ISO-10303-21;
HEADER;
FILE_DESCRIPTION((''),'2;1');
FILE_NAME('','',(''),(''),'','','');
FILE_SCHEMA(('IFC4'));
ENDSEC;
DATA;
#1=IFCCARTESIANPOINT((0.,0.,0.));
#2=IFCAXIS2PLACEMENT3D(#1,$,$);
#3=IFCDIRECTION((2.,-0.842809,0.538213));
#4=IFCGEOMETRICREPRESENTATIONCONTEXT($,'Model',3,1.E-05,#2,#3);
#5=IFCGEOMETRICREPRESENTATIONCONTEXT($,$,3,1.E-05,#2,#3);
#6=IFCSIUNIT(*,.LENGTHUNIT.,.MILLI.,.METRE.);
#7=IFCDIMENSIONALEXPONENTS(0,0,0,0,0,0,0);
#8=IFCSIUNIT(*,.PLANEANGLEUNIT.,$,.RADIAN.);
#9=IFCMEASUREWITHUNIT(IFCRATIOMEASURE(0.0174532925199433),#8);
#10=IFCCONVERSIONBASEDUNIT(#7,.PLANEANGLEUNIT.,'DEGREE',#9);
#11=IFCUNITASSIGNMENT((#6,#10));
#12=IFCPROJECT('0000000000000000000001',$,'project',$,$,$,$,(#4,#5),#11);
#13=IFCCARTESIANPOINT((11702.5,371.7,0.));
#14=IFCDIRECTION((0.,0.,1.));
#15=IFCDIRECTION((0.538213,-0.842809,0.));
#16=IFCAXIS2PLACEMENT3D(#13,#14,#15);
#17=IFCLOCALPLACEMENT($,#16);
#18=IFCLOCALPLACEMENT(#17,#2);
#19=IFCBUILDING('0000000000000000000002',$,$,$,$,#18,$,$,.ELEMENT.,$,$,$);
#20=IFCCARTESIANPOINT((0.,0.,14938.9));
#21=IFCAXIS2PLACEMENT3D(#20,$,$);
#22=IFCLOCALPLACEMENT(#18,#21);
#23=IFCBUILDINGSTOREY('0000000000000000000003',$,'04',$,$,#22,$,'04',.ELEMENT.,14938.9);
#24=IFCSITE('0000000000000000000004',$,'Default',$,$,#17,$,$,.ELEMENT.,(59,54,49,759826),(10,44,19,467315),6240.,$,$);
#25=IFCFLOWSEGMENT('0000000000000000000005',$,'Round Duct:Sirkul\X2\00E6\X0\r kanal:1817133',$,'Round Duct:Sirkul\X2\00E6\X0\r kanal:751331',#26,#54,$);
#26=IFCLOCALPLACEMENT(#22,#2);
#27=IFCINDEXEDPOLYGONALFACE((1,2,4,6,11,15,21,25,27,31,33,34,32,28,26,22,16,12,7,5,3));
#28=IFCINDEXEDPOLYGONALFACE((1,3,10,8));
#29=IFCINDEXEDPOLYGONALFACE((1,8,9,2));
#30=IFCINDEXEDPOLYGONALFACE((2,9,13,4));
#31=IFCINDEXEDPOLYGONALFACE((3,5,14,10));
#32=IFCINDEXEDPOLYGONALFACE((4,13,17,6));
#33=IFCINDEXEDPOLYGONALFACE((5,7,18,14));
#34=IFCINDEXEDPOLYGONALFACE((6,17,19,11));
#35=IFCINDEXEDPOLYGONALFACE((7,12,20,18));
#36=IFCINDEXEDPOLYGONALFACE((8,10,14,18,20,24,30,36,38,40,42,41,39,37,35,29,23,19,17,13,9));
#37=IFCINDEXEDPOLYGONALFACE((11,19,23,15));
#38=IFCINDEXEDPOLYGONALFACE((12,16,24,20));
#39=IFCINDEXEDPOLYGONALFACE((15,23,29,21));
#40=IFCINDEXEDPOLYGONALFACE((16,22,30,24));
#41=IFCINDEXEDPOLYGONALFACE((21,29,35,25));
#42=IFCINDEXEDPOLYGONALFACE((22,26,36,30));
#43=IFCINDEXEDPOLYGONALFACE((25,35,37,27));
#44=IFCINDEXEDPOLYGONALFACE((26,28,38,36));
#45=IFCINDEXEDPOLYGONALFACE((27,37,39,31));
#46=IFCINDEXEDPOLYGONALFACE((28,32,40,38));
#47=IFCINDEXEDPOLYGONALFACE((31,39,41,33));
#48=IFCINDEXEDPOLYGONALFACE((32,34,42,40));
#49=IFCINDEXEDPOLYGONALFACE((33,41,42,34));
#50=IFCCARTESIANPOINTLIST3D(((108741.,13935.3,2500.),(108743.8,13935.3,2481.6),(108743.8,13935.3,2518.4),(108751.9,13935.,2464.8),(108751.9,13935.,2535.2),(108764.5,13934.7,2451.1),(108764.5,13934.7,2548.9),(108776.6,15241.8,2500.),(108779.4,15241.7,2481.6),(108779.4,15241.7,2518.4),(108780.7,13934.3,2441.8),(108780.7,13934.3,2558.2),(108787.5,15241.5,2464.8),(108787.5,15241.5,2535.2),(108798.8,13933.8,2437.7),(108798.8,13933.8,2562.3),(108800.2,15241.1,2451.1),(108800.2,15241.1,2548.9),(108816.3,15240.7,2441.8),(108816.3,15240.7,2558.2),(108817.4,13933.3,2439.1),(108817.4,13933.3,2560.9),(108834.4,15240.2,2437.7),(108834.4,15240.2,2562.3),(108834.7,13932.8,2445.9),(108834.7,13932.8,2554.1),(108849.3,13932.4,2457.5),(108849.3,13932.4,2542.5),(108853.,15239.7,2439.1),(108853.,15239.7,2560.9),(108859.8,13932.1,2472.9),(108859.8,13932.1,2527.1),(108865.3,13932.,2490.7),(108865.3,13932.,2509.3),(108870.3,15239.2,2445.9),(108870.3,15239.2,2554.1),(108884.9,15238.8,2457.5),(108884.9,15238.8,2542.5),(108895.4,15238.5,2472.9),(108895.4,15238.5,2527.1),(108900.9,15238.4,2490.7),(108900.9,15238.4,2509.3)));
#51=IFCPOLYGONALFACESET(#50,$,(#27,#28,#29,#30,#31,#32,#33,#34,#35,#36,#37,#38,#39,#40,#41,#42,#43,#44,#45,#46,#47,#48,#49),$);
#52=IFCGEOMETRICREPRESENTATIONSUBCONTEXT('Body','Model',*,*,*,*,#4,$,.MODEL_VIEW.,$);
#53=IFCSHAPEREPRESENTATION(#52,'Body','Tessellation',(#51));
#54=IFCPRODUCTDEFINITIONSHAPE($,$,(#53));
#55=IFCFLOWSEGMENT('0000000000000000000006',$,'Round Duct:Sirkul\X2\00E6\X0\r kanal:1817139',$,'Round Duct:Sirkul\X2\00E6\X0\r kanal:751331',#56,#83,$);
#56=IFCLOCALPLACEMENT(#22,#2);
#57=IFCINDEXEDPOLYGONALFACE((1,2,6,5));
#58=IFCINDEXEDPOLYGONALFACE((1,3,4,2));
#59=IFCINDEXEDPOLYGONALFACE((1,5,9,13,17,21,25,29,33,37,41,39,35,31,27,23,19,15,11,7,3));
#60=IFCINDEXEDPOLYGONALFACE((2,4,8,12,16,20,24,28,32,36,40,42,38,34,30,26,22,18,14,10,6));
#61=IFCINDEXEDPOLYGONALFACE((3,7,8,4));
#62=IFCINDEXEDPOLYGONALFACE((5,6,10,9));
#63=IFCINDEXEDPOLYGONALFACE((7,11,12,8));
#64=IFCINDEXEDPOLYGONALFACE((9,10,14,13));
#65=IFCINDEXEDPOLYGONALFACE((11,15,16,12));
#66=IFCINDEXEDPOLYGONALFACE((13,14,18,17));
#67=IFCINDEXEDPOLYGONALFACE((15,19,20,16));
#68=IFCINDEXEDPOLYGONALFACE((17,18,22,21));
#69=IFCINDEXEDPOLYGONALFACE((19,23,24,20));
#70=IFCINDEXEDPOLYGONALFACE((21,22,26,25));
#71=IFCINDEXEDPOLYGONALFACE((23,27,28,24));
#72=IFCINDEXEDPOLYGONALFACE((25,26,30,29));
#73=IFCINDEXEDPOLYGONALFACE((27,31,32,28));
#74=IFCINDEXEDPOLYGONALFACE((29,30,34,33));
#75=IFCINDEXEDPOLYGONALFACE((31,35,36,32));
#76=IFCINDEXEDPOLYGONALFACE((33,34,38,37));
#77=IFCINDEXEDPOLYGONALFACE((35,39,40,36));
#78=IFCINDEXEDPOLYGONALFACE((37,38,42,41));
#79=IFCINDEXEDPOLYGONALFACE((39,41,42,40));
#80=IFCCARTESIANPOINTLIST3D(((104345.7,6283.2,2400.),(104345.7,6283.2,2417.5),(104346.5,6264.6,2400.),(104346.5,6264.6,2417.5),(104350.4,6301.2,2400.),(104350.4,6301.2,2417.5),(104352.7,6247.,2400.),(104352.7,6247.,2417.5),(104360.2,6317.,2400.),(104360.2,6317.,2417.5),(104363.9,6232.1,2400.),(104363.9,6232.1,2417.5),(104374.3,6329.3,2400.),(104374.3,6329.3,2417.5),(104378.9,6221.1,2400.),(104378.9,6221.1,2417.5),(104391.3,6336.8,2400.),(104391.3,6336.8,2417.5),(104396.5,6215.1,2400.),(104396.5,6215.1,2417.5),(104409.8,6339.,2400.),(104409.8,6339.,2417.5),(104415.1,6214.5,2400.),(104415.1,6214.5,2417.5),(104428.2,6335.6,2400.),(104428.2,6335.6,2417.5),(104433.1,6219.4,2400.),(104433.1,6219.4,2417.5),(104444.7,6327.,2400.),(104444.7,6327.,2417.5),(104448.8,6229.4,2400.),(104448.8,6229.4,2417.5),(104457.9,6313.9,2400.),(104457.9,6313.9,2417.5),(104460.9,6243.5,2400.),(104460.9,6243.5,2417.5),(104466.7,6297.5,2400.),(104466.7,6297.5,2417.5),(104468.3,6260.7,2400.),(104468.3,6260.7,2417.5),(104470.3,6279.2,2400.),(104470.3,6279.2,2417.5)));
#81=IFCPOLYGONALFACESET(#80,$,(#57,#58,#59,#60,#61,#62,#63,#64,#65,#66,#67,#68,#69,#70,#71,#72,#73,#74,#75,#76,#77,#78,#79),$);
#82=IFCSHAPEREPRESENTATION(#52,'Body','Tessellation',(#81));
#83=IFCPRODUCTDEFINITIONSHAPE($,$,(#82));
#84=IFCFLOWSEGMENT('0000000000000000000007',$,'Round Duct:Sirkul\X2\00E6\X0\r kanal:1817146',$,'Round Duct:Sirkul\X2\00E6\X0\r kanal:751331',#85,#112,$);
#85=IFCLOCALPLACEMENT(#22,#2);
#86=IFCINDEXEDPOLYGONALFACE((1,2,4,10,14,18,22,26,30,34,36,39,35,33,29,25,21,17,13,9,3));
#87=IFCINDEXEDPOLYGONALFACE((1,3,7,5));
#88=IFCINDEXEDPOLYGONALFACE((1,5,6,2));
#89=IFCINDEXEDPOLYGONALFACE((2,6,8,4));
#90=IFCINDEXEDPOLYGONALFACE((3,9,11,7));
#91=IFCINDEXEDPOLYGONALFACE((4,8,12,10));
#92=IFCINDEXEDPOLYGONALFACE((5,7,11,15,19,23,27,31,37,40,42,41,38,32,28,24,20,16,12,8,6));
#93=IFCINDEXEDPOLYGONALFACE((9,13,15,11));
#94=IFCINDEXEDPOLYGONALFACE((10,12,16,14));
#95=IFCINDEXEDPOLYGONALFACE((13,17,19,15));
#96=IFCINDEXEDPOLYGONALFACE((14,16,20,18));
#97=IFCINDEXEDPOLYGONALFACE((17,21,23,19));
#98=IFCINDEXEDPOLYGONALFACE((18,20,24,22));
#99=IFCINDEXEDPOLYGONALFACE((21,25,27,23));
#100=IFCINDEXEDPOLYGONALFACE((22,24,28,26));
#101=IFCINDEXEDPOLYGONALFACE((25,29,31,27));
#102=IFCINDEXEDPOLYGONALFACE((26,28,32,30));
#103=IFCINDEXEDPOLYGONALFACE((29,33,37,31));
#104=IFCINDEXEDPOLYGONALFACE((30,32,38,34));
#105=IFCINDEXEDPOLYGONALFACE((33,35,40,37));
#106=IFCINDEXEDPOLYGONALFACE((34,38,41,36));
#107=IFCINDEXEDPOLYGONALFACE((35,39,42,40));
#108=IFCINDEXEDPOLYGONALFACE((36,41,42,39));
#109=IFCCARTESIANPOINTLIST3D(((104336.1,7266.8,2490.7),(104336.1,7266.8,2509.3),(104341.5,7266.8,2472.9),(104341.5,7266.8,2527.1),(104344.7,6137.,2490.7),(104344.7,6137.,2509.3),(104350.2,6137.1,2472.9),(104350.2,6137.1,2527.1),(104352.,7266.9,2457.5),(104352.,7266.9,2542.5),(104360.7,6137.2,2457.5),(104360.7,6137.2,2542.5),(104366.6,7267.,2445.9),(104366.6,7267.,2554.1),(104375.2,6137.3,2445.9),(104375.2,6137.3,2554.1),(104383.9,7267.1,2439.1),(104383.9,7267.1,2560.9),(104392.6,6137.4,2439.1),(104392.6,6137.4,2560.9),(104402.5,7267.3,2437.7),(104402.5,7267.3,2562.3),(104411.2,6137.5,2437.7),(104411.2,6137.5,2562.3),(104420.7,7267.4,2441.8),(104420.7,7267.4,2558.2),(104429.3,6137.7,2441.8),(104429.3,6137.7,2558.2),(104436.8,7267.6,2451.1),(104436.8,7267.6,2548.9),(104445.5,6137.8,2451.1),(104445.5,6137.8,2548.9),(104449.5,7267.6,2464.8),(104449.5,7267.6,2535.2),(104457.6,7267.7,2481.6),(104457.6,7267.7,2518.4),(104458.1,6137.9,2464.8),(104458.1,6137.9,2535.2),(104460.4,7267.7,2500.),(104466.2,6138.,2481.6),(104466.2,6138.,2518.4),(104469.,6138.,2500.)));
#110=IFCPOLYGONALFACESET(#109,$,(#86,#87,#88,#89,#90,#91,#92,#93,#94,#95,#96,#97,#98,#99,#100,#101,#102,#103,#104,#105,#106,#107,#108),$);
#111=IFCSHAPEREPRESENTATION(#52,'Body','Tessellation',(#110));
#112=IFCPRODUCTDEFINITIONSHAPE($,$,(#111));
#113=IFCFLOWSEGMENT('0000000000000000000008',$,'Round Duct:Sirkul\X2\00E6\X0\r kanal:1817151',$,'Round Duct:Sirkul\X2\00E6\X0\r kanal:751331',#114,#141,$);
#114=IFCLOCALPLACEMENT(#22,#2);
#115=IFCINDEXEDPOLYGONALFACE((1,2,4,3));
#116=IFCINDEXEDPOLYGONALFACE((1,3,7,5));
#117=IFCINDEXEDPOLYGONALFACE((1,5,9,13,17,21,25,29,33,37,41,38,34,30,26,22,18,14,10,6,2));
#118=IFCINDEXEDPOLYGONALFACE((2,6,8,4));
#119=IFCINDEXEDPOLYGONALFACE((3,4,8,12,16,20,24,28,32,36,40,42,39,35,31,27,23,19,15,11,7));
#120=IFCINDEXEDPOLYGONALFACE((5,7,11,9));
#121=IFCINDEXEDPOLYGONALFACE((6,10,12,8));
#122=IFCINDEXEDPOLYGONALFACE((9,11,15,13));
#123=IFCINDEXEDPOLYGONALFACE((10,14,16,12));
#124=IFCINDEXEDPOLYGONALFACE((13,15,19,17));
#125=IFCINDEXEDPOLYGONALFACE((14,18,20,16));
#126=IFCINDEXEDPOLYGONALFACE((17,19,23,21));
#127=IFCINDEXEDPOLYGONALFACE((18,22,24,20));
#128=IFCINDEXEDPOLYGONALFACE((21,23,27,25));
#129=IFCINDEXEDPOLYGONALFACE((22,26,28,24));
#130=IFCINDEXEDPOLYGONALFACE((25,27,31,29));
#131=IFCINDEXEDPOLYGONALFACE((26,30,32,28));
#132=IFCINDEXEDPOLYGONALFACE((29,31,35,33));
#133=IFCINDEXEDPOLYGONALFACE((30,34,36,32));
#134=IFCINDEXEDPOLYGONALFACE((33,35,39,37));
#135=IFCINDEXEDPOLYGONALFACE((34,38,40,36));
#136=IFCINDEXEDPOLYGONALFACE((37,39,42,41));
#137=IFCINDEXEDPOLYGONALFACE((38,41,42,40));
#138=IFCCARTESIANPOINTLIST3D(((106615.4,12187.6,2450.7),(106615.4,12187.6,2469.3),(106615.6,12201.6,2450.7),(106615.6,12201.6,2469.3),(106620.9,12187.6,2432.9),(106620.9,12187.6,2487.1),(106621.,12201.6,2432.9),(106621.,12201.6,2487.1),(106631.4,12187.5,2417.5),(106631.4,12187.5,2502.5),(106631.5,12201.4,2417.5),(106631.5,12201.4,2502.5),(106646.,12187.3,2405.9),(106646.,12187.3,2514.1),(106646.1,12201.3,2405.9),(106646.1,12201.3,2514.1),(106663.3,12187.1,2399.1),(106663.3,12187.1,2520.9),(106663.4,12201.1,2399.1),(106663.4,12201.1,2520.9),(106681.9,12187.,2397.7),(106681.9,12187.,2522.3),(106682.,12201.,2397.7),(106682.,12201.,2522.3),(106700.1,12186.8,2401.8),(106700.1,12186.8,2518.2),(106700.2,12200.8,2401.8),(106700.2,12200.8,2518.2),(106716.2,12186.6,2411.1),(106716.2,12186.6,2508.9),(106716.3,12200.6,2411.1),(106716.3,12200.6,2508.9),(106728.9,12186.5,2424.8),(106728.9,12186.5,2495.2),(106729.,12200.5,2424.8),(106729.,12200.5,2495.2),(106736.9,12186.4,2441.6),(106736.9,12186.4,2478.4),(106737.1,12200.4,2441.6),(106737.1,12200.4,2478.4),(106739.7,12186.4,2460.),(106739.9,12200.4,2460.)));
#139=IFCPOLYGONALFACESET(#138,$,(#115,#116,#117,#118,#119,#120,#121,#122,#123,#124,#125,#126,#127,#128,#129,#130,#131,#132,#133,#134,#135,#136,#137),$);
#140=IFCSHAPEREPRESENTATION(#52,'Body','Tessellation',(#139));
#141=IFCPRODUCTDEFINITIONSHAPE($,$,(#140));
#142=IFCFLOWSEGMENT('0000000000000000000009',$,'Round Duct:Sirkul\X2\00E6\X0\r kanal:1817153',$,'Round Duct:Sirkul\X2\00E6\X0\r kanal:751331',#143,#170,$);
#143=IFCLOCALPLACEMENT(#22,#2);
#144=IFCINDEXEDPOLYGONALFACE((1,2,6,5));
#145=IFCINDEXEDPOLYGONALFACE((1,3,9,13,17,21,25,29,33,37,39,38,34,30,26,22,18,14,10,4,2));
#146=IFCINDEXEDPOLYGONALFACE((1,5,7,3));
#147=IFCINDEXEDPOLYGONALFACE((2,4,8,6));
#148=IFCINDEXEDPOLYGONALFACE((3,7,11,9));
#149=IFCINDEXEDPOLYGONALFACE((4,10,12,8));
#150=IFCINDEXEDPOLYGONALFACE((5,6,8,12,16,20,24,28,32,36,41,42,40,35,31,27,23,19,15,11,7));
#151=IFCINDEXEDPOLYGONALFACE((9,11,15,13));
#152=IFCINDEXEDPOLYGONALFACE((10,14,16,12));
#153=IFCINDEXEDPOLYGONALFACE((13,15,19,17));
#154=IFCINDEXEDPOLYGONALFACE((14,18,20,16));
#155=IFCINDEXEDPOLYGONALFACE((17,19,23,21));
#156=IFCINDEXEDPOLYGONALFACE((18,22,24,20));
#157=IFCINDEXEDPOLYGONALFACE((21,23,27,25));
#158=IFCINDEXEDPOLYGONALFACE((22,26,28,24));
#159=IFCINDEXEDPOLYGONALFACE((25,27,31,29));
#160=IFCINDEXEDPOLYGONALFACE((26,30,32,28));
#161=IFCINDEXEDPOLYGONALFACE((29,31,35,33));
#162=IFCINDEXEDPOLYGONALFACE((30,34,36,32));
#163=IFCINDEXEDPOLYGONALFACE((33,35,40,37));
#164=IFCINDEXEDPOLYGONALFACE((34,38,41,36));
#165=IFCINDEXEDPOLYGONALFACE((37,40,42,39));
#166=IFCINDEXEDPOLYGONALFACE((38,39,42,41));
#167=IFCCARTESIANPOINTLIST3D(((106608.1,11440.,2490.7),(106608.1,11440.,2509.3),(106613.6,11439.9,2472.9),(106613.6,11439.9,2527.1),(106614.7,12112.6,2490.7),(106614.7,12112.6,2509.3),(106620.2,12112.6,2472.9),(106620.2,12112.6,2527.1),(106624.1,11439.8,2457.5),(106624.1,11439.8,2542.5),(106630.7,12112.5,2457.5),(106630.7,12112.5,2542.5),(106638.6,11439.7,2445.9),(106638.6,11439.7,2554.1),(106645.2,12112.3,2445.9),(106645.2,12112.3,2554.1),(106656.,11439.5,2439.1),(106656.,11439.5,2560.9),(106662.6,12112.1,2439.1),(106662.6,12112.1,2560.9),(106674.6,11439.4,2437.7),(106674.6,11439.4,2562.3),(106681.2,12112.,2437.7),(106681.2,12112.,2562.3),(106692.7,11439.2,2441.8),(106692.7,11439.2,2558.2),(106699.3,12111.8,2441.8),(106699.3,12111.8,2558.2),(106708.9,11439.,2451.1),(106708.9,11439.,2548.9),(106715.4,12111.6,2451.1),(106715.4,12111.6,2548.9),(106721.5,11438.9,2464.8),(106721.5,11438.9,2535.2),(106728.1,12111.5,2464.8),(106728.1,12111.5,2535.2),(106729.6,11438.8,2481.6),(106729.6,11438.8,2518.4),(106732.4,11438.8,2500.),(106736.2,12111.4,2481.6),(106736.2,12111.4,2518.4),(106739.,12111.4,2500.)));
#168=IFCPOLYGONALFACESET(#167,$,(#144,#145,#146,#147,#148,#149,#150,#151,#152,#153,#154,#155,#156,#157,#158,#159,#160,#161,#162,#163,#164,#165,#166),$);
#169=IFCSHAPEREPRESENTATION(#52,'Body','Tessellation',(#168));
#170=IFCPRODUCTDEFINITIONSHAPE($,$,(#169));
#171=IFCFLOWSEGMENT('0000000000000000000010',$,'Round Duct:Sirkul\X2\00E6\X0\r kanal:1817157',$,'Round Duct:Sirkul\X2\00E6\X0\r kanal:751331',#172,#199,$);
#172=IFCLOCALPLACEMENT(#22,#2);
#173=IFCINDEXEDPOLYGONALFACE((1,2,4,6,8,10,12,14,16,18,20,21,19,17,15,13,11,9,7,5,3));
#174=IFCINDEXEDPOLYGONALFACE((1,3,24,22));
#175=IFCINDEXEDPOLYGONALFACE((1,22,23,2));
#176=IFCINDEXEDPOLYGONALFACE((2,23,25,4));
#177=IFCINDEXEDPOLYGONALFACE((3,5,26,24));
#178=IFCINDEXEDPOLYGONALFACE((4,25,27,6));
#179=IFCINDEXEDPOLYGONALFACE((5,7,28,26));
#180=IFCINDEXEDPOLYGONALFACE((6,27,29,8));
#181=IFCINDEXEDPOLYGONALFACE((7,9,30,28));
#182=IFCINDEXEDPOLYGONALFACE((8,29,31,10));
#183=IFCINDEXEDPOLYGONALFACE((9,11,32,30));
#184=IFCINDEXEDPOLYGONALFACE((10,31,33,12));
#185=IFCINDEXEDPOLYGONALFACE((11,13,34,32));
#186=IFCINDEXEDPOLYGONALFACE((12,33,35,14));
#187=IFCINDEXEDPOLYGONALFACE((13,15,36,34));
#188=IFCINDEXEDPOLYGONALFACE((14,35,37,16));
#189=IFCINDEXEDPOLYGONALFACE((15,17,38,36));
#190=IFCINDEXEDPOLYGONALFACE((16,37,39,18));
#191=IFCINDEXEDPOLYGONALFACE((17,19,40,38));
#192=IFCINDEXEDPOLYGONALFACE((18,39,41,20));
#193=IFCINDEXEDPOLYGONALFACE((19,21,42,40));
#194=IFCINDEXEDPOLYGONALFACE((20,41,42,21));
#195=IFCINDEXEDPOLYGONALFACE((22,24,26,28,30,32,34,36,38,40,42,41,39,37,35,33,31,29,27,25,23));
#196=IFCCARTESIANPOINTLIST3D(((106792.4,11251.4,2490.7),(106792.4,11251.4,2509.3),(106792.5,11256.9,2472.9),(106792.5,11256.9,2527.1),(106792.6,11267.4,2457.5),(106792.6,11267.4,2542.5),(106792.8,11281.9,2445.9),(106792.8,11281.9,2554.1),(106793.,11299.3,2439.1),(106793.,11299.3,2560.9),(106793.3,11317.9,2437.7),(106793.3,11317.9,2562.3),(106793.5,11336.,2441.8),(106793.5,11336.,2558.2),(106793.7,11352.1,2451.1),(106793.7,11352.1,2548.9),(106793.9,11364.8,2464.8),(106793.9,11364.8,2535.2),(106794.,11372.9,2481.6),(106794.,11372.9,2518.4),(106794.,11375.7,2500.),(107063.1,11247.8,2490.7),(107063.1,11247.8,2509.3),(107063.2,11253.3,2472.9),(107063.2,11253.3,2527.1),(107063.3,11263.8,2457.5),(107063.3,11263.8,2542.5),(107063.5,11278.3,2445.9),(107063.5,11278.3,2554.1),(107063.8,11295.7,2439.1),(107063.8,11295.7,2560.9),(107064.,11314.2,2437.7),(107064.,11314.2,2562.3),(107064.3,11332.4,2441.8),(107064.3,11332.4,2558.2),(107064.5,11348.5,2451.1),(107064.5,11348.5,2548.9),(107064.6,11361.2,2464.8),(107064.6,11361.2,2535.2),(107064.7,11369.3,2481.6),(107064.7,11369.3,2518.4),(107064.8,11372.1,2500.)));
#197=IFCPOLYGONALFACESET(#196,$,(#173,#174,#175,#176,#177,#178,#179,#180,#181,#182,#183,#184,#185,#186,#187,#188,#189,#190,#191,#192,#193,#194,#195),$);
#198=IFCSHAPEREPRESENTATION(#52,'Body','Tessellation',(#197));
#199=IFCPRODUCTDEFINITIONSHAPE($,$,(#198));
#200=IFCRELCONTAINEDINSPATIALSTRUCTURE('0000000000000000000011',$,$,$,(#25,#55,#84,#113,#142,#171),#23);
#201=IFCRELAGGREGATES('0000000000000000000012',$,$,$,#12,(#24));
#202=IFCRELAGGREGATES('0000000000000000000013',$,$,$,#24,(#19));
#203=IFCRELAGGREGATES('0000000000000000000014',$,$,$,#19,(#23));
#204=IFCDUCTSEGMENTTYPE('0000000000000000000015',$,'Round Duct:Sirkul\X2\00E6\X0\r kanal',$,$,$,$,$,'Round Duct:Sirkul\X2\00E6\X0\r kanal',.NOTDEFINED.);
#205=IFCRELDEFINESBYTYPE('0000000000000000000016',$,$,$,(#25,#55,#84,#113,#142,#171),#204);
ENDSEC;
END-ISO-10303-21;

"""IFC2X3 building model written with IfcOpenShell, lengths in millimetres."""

from ifc_helpers import new_model, entity, si_unit, converted_unit, direction, frame, frame_2d, origin, origin_2d_with_axis, place, context, subcontext, project, spatial, circle, extrude, type_object, element, save


model = new_model("IFC2X3")

# Units and contexts
model_context = context("Model", 3, precision=1e-05, world=origin(), true_north=direction((2.0, -0.842809, 0.538213)))
context_of_model = context(None, 3, precision=1e-05, world=origin(), true_north=direction((2.0, -0.842809, 0.538213)))
body_context = subcontext(model_context, "Body", "Model", "MODEL_VIEW")
ifc_project = project(units=[si_unit("LENGTHUNIT", "METRE", prefix="MILLI"), converted_unit("PLANEANGLEUNIT", "DEGREE", entity("IfcRatioMeasure", 0.0174532925199433), si_unit("PLANEANGLEUNIT", "RADIAN"), dimensions=[0, 0, 0, 0, 0, 0, 0])], contexts=[model_context, context_of_model])

# Site, building, storey
site_placement = place(None, frame((11702.5, 371.7, 0.0), z_axis=(0.0, 0.0, 1.0), x_axis=(0.538213, -0.842809, 0.0)))
site = spatial("IfcSite", under=ifc_project, at=site_placement, Name="Default", CompositionType="ELEMENT", RefLatitude=(59, 54, 49, 759826), RefLongitude=(10, 44, 19, 467315), RefElevation=6240.0)
building_placement = place(site_placement, origin())
building = spatial("IfcBuilding", under=site, at=building_placement, CompositionType="ELEMENT")
storey_placement = place(building_placement, frame((0.0, 0.0, 14938.9)))
storey = spatial("IfcBuildingStorey", under=building, at=storey_placement, Name="04", LongName="04", CompositionType="ELEMENT", Elevation=14938.9)

# Flow segments
duct_segment_type = type_object("IfcDuctSegmentType", Name="Round Duct:Sirkulær kanal", ElementType="Round Duct:Sirkulær kanal", PredefinedType="NOTDEFINED")
flow_segment_1_placement = place(storey_placement, origin())
element("IfcFlowSegment", 1, at=flow_segment_1_placement, inside=storey, type_object=duct_segment_type, Name="Round Duct:Sirkulær kanal:1817133", ObjectType="Round Duct:Sirkulær kanal:751331", context=body_context, shape_type="SweptSolid", body=[
    extrude(circle(Radius=62.5, at=origin_2d_with_axis()), frame((108803.5, 13933.6, 2500.0), z_axis=(0.02726, 0.999628, 0.0), x_axis=(-0.999628, 0.02726, 0.0)), (0.0, 0.0, 1.0), 1306.9),
])
flow_segment_2_placement = place(storey_placement, origin())
element("IfcFlowSegment", 2, at=flow_segment_2_placement, inside=storey, type_object=duct_segment_type, Name="Round Duct:Sirkulær kanal:1817139", ObjectType="Round Duct:Sirkulær kanal:751331", context=body_context, shape_type="SweptSolid", body=[
    extrude(circle(Radius=62.5, at=frame_2d((0.0, 0.0), x_axis=(1.0, 0.0))), frame((104407.8, 6276.5, 2400.0), z_axis=(0.0, 0.0, 1.0), x_axis=(0.999095, 0.042537, 0.0)), (0.0, 0.0, 1.0), 17.5),
])
flow_segment_3_placement = place(storey_placement, origin())
element("IfcFlowSegment", 3, at=flow_segment_3_placement, inside=storey, type_object=duct_segment_type, Name="Round Duct:Sirkulær kanal:1817146", ObjectType="Round Duct:Sirkulær kanal:751331", context=body_context, shape_type="SweptSolid", body=[
    extrude(circle(Radius=62.5, at=origin_2d_with_axis()), frame((104406.5, 6137.5, 2500.0), z_axis=(-0.007643, 0.999971, 0.0), x_axis=(0.999971, 0.007643, 0.0)), (0.0, 0.0, 1.0), 1129.8),
])
flow_segment_4_placement = place(storey_placement, origin())
element("IfcFlowSegment", 4, at=flow_segment_4_placement, inside=storey, type_object=duct_segment_type, Name="Round Duct:Sirkulær kanal:1817151", ObjectType="Round Duct:Sirkulær kanal:751331", context=body_context, shape_type="SweptSolid", body=[
    extrude(circle(Radius=62.5, at=frame_2d((0.0, 0.0), x_axis=(1.0, 0.0))), frame((106677.2, 12187.0, 2460.0), z_axis=(0.00981, 0.999952, 0.0), x_axis=(0.999952, -0.00981, 0.0)), (0.0, 0.0, 1.0), 14.0),
])
flow_segment_5_placement = place(storey_placement, origin())
element("IfcFlowSegment", 5, at=flow_segment_5_placement, inside=storey, type_object=duct_segment_type, Name="Round Duct:Sirkulær kanal:1817153", ObjectType="Round Duct:Sirkulær kanal:751331", context=body_context, shape_type="SweptSolid", body=[
    extrude(circle(Radius=62.5, at=origin_2d_with_axis()), frame((106669.9, 11439.4, 2500.0), z_axis=(0.00981, 0.999952, 0.0), x_axis=(0.999952, -0.00981, 0.0)), (0.0, 0.0, 1.0), 672.6),
])
flow_segment_6_placement = place(storey_placement, origin())
element("IfcFlowSegment", 6, at=flow_segment_6_placement, inside=storey, type_object=duct_segment_type, Name="Round Duct:Sirkulær kanal:1817157", ObjectType="Round Duct:Sirkulær kanal:751331", context=body_context, shape_type="SweptSolid", body=[
    extrude(circle(Radius=62.5, at=origin_2d_with_axis()), frame((107064.0, 11309.6, 2500.0), z_axis=(-0.999911, 0.013345, 0.0), x_axis=(0.013345, 0.999911, 0.0)), (0.0, 0.0, 1.0), 270.8),
])

save(model, "model.ifc")
